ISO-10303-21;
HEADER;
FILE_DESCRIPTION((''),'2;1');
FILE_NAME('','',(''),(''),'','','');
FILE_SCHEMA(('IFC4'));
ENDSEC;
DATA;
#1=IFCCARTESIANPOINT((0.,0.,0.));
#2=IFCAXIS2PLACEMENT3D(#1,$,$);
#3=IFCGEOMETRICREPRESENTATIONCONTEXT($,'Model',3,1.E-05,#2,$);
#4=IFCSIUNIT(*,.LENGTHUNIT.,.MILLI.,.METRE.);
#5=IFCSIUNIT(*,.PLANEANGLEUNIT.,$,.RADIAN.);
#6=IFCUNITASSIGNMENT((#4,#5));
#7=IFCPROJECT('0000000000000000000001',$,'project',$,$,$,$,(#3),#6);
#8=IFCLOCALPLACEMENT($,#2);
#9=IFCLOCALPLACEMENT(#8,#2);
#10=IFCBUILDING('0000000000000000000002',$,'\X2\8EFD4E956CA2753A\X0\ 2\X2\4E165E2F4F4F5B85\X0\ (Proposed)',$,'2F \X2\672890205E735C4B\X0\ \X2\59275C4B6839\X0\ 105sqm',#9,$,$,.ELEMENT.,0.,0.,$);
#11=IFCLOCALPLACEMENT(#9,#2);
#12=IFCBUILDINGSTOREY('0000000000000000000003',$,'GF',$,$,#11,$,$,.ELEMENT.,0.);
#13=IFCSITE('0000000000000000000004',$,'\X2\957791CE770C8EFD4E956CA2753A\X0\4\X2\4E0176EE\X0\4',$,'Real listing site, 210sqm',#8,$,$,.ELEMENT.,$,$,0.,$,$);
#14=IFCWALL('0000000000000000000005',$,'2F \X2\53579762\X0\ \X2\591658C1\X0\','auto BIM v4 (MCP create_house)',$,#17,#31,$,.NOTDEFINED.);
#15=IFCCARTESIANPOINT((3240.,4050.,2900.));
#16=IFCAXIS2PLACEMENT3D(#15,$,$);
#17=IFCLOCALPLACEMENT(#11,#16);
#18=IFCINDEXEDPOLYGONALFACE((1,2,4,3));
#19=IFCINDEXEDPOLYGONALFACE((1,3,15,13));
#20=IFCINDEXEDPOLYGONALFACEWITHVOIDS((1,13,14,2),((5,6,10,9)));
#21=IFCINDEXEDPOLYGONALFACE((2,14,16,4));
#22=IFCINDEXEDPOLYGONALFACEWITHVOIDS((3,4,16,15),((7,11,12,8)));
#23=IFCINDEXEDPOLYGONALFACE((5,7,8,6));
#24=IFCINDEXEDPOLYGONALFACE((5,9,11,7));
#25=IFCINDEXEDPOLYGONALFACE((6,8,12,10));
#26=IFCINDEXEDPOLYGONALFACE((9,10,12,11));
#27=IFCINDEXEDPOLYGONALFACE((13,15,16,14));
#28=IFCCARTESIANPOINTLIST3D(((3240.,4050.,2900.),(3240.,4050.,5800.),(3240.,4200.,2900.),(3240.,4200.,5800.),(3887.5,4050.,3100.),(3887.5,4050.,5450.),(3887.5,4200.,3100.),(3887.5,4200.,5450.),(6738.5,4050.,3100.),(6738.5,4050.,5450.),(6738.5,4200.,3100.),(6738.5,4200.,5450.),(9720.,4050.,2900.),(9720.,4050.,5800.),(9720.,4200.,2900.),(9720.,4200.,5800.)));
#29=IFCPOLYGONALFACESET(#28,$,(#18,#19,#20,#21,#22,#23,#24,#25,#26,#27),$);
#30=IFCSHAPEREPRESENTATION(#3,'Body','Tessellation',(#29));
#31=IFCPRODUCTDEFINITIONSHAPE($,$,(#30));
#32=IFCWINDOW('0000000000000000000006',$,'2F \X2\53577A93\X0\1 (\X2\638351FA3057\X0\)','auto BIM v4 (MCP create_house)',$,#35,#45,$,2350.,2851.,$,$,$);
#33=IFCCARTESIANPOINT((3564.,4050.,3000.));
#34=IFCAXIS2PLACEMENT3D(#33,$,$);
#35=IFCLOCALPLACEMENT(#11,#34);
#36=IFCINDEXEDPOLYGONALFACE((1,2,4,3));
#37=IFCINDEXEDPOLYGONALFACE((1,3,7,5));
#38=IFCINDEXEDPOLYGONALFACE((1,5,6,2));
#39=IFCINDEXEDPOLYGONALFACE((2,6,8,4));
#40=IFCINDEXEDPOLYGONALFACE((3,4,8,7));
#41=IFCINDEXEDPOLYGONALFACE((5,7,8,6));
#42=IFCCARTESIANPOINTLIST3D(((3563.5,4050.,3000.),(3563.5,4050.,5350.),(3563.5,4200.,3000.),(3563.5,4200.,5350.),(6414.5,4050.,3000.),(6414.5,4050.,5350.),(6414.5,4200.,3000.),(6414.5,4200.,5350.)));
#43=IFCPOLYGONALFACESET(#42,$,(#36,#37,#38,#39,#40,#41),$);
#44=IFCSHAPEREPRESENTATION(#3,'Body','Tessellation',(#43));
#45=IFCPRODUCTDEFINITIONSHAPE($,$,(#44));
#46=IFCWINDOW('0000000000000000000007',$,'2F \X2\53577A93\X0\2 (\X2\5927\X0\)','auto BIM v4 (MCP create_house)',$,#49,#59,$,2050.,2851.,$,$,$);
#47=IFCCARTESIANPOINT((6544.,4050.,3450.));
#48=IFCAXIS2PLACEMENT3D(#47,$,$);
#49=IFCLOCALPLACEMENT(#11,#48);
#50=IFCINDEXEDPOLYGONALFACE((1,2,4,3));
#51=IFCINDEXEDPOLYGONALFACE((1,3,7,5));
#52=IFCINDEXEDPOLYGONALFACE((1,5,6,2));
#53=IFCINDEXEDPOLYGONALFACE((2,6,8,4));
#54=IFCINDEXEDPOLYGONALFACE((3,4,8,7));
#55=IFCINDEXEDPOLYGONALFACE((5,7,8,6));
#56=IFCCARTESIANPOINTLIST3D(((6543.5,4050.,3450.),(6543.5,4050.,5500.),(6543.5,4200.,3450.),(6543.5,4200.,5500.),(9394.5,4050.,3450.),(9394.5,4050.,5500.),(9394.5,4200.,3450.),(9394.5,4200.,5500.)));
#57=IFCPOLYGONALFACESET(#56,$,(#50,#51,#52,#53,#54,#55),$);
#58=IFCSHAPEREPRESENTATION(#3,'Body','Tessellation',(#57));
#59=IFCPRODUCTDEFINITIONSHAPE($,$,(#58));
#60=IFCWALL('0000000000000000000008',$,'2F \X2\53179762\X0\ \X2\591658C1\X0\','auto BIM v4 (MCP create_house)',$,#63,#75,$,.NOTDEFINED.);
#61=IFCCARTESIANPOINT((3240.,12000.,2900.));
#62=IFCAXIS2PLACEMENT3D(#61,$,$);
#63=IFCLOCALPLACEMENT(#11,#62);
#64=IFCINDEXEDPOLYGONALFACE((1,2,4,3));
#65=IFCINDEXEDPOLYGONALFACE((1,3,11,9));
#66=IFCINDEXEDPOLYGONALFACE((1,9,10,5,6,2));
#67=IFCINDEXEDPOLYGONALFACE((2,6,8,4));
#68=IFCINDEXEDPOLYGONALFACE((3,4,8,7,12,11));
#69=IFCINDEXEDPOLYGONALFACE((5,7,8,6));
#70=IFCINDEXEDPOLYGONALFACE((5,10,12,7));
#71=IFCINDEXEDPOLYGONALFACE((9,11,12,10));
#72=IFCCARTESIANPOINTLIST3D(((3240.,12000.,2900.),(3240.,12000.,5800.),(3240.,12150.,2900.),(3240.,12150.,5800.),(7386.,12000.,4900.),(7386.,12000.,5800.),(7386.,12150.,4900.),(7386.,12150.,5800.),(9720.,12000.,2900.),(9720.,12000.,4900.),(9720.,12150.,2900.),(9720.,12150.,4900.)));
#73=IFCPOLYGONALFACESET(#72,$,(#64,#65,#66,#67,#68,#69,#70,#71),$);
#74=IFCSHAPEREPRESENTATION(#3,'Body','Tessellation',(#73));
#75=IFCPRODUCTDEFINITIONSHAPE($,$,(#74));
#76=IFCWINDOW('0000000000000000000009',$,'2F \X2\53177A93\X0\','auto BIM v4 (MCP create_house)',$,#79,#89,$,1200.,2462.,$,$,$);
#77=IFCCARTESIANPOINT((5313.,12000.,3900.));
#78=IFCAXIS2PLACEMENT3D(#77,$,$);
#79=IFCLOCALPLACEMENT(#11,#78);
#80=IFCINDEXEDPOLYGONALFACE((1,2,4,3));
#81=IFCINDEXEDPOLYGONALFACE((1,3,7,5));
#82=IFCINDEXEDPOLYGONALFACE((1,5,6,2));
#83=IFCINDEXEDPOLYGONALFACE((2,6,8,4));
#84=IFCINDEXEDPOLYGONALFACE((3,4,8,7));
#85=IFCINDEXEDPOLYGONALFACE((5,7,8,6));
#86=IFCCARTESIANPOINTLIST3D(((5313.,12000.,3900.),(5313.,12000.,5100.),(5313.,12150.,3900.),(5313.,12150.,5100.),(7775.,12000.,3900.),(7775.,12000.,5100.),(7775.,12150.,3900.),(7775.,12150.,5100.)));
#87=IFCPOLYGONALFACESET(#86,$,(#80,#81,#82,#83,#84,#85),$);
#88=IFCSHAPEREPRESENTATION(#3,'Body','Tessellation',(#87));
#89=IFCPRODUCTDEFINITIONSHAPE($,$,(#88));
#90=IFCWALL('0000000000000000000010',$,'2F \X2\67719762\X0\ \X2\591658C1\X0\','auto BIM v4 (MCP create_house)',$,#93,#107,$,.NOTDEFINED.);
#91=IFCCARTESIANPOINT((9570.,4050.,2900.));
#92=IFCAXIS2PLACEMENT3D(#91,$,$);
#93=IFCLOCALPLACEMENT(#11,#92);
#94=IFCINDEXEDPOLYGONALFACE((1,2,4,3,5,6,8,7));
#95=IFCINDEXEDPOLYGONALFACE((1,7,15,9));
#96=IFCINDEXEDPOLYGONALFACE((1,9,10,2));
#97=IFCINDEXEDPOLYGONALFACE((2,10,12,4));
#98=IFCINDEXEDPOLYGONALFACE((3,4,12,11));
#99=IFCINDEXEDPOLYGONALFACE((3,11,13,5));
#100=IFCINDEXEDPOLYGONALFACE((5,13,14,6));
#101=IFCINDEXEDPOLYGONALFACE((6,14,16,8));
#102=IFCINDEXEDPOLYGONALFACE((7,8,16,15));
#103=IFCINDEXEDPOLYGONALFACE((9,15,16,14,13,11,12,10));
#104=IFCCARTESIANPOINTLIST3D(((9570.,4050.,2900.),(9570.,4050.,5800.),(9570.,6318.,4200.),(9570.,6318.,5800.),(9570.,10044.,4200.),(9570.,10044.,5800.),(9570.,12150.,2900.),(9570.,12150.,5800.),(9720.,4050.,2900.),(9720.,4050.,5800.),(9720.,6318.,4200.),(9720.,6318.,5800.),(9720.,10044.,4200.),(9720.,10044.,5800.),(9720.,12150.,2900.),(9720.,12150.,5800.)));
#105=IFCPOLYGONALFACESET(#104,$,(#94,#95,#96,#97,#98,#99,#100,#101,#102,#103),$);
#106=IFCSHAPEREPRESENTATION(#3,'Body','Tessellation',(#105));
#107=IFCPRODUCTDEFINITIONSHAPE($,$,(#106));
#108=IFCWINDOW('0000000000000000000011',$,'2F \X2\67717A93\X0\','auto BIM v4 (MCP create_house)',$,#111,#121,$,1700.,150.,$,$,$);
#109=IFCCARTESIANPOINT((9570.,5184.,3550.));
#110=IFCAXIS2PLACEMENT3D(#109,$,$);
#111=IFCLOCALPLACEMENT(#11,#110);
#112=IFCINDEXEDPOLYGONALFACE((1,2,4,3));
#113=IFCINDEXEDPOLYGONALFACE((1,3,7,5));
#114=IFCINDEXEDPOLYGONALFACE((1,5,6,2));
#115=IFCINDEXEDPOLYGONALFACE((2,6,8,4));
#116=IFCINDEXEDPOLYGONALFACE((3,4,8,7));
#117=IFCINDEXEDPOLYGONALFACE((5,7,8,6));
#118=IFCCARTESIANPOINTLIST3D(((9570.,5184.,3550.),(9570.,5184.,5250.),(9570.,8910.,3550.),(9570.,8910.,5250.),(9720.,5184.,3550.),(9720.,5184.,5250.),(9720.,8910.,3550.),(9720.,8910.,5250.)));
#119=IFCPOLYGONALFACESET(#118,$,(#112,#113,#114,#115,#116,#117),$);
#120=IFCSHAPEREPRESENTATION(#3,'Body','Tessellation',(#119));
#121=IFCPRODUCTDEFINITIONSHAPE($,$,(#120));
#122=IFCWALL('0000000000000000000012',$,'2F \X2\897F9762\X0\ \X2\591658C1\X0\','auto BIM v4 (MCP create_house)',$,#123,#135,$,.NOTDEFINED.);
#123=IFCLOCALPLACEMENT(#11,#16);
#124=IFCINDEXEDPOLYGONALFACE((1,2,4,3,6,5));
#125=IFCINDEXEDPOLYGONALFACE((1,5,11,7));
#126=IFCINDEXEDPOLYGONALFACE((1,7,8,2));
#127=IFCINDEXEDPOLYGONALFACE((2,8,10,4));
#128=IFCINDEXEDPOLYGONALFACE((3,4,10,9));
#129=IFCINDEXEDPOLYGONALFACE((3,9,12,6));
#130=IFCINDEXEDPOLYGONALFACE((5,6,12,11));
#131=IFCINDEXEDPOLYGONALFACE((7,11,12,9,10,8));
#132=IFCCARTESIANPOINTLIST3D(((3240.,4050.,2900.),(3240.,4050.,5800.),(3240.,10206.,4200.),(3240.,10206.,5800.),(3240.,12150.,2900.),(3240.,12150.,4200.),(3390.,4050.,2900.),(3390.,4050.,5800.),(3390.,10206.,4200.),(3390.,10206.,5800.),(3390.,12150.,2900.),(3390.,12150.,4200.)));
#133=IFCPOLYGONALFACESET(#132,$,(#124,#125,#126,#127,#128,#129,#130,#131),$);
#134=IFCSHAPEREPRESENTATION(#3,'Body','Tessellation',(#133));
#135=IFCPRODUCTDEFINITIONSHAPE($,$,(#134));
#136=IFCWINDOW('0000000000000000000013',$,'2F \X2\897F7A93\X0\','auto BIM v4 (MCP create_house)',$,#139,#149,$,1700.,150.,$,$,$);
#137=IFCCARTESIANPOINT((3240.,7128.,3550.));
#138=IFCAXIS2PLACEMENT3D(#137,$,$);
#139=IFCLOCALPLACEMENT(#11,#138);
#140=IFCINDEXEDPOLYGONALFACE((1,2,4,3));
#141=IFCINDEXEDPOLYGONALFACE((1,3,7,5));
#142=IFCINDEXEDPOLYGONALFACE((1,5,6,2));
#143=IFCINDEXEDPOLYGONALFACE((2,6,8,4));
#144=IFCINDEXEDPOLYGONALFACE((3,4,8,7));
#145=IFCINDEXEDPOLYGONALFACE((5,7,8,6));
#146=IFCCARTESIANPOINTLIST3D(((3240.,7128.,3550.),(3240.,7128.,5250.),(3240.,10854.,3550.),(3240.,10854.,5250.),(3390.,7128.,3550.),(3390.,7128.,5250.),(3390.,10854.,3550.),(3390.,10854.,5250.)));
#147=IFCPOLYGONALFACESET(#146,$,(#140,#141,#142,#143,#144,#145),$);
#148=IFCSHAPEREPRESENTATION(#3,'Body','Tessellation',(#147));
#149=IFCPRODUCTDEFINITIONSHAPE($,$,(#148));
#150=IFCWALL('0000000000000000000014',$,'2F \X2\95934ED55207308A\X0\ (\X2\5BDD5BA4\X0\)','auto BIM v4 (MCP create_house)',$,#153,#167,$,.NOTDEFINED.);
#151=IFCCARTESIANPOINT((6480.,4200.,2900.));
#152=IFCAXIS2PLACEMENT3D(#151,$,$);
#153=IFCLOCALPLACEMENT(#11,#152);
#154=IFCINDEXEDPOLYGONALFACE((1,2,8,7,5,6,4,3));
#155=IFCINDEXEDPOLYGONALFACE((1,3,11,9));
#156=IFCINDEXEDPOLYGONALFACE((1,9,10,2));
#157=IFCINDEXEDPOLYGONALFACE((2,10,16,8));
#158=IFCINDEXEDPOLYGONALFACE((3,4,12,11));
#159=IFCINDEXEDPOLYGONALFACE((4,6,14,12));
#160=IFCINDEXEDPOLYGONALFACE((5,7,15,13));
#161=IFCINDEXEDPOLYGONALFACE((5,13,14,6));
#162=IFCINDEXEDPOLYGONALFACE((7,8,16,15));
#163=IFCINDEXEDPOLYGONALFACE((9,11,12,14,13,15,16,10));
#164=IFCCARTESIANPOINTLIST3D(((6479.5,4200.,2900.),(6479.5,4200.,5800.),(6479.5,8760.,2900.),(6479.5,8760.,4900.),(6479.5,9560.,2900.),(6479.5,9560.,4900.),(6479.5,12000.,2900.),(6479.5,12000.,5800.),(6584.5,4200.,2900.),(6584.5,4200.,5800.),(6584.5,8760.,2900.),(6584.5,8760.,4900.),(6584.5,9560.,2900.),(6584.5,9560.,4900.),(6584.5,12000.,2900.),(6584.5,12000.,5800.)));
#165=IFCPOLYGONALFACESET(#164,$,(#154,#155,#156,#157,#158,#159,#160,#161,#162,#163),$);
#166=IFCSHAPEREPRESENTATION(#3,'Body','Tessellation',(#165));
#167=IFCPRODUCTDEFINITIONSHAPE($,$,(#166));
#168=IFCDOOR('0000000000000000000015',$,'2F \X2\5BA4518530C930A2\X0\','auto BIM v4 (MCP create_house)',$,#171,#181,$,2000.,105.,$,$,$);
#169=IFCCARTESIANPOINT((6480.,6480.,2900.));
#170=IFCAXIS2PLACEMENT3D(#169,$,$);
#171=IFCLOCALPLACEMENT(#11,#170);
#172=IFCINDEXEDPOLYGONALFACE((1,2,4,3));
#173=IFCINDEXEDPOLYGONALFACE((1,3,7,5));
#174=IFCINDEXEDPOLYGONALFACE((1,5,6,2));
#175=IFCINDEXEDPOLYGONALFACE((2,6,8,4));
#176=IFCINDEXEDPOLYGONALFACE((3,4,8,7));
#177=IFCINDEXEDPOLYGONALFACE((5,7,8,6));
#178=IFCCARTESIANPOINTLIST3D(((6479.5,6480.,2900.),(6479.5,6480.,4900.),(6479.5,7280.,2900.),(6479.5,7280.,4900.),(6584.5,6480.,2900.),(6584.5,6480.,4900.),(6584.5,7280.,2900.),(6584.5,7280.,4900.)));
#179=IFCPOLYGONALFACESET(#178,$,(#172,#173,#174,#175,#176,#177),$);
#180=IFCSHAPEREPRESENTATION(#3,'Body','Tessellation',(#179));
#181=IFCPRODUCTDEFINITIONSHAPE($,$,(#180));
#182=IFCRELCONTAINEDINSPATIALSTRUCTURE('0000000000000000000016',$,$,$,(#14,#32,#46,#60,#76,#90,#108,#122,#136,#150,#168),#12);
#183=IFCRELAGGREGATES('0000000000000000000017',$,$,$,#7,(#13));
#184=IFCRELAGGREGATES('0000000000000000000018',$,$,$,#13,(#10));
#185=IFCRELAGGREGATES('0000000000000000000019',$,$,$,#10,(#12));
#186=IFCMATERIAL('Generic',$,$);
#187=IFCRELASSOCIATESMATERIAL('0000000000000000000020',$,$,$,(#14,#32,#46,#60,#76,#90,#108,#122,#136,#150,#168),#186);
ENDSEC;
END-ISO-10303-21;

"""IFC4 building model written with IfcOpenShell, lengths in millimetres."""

from ifc_helpers import new_model, si_unit, frame, frame_2d, origin, place, context, project, spatial, rectangle, extrude, material, element, fill, save


model = new_model("IFC4")

# Units and contexts
model_context = context("Model", 3, precision=1e-05, world=origin())
ifc_project = project(units=[si_unit("LENGTHUNIT", "METRE", prefix="MILLI"), si_unit("PLANEANGLEUNIT", "RADIAN")], contexts=[model_context])

# Site, building, storey
site_placement = place(None, origin())
site = spatial("IfcSite", under=ifc_project, at=site_placement, Name="長野県軽井沢町4丁目4", ObjectType="Real listing site, 210sqm", CompositionType="ELEMENT", RefElevation=0.0)
building_placement = place(site_placement, origin())
building = spatial("IfcBuilding", under=site, at=building_placement, Name="軽井沢町 2世帯住宅 (Proposed)", ObjectType="2F 木造平屋 大屋根 105sqm", CompositionType="ELEMENT", ElevationOfRefHeight=0.0, ElevationOfTerrain=0.0)
storey_placement = place(building_placement, origin())
storey = spatial("IfcBuildingStorey", under=building, at=storey_placement, Name="GF", CompositionType="ELEMENT", Elevation=0.0)

# Shared definitions
ifc_material = material(Name="Generic")

# Wall, openings, windows
wall_1_placement = place(storey_placement, frame((3240.0, 4050.0, 2900.0)))
wall_1 = element("IfcWall", 1, at=wall_1_placement, inside=storey, material=ifc_material, Name="2F 南面 外壁", Description="auto BIM v4 (MCP create_house)", PredefinedType="NOTDEFINED", context=model_context, shape_type="SweptSolid", body=[
    extrude(rectangle(XDim=6480.0, YDim=150.0, at=frame_2d((3240.0, 75.0))), frame((3240.0, 4050.0, 2900.0)), (0.0, 0.0, 1.0), 2900.0),
])
opening_1_placement = place(storey_placement, frame((3564.0, 4050.0, 3000.0)))
opening_1 = element("IfcOpeningElement", 2, at=opening_1_placement, cuts=wall_1, PredefinedType="NOTDEFINED", context=model_context, shape_type="SweptSolid", body=[
    extrude(rectangle(XDim=2851.0, YDim=150.0, at=frame_2d((1425.0, 75.0))), frame((3564.0, 4050.0, 3000.0)), (0.0, 0.0, 1.0), 2350.0),
])
opening_2_placement = place(storey_placement, frame((6544.0, 4050.0, 3450.0)))
opening_2 = element("IfcOpeningElement", 3, at=opening_2_placement, cuts=wall_1, PredefinedType="NOTDEFINED", context=model_context, shape_type="SweptSolid", body=[
    extrude(rectangle(XDim=2851.0, YDim=150.0, at=frame_2d((1425.0, 75.0))), frame((6544.0, 4050.0, 3450.0)), (0.0, 0.0, 1.0), 2050.0),
])
window_1_placement = place(storey_placement, frame((3564.0, 4050.0, 3000.0)))
window_1 = element("IfcWindow", 4, at=window_1_placement, inside=storey, material=ifc_material, Name="2F 南窓1 (掃出し)", Description="auto BIM v4 (MCP create_house)", OverallHeight=2350.0, OverallWidth=2851.0, context=model_context, shape_type="SweptSolid", body=[
    extrude(rectangle(XDim=2851.0, YDim=150.0, at=frame_2d((1425.0, 75.0))), frame((3564.0, 4050.0, 3000.0)), (0.0, 0.0, 1.0), 2350.0),
])
fill(opening_1, window_1)
window_2_placement = place(storey_placement, frame((6544.0, 4050.0, 3450.0)))
window_2 = element("IfcWindow", 5, at=window_2_placement, inside=storey, material=ifc_material, Name="2F 南窓2 (大)", Description="auto BIM v4 (MCP create_house)", OverallHeight=2050.0, OverallWidth=2851.0, context=model_context, shape_type="SweptSolid", body=[
    extrude(rectangle(XDim=2851.0, YDim=150.0, at=frame_2d((1425.0, 75.0))), frame((6544.0, 4050.0, 3450.0)), (0.0, 0.0, 1.0), 2050.0),
])
fill(opening_2, window_2)

# Walls, openings, windows
wall_2_placement = place(storey_placement, frame((3240.0, 12000.0, 2900.0)))
wall_2 = element("IfcWall", 6, at=wall_2_placement, inside=storey, material=ifc_material, Name="2F 北面 外壁", Description="auto BIM v4 (MCP create_house)", PredefinedType="NOTDEFINED", context=model_context, shape_type="SweptSolid", body=[
    extrude(rectangle(XDim=6480.0, YDim=150.0, at=frame_2d((3240.0, 75.0))), frame((3240.0, 12000.0, 2900.0)), (0.0, 0.0, 1.0), 2900.0),
])
opening_3_placement = place(storey_placement, frame((5313.0, 12000.0, 3900.0)))
opening_3 = element("IfcOpeningElement", 7, at=opening_3_placement, cuts=wall_2, PredefinedType="NOTDEFINED", context=model_context, shape_type="SweptSolid", body=[
    extrude(rectangle(XDim=2462.0, YDim=150.0, at=frame_2d((1231.0, 75.0))), frame((5313.0, 12000.0, 3900.0)), (0.0, 0.0, 1.0), 1200.0),
])
window_3_placement = place(storey_placement, frame((5313.0, 12000.0, 3900.0)))
window_3 = element("IfcWindow", 8, at=window_3_placement, inside=storey, material=ifc_material, Name="2F 北窓", Description="auto BIM v4 (MCP create_house)", OverallHeight=1200.0, OverallWidth=2462.0, context=model_context, shape_type="SweptSolid", body=[
    extrude(rectangle(XDim=2462.0, YDim=150.0, at=frame_2d((1231.0, 75.0))), frame((5313.0, 12000.0, 3900.0)), (0.0, 0.0, 1.0), 1200.0),
])
fill(opening_3, window_3)
wall_3_placement = place(storey_placement, frame((9570.0, 4050.0, 2900.0)))
wall_3 = element("IfcWall", 9, at=wall_3_placement, inside=storey, material=ifc_material, Name="2F 東面 外壁", Description="auto BIM v4 (MCP create_house)", PredefinedType="NOTDEFINED", context=model_context, shape_type="SweptSolid", body=[
    extrude(rectangle(XDim=150.0, YDim=8100.0, at=frame_2d((75.0, 4050.0))), frame((9570.0, 4050.0, 2900.0)), (0.0, 0.0, 1.0), 2900.0),
])
opening_4_placement = place(storey_placement, frame((9570.0, 5184.0, 3550.0)))
opening_4 = element("IfcOpeningElement", 10, at=opening_4_placement, cuts=wall_3, PredefinedType="NOTDEFINED", context=model_context, shape_type="SweptSolid", body=[
    extrude(rectangle(XDim=150.0, YDim=3726.0, at=frame_2d((75.0, 1863.0))), frame((9570.0, 5184.0, 3550.0)), (0.0, 0.0, 1.0), 1700.0),
])
window_4_placement = place(storey_placement, frame((9570.0, 5184.0, 3550.0)))
window_4 = element("IfcWindow", 11, at=window_4_placement, inside=storey, material=ifc_material, Name="2F 東窓", Description="auto BIM v4 (MCP create_house)", OverallHeight=1700.0, OverallWidth=150.0, context=model_context, shape_type="SweptSolid", body=[
    extrude(rectangle(XDim=150.0, YDim=3726.0, at=frame_2d((75.0, 1863.0))), frame((9570.0, 5184.0, 3550.0)), (0.0, 0.0, 1.0), 1700.0),
])
fill(opening_4, window_4)
wall_4_placement = place(storey_placement, frame((3240.0, 4050.0, 2900.0)))
wall_4 = element("IfcWall", 12, at=wall_4_placement, inside=storey, material=ifc_material, Name="2F 西面 外壁", Description="auto BIM v4 (MCP create_house)", PredefinedType="NOTDEFINED", context=model_context, shape_type="SweptSolid", body=[
    extrude(rectangle(XDim=150.0, YDim=8100.0, at=frame_2d((75.0, 4050.0))), frame((3240.0, 4050.0, 2900.0)), (0.0, 0.0, 1.0), 2900.0),
])
opening_5_placement = place(storey_placement, frame((3240.0, 7128.0, 3550.0)))
opening_5 = element("IfcOpeningElement", 13, at=opening_5_placement, cuts=wall_4, PredefinedType="NOTDEFINED", context=model_context, shape_type="SweptSolid", body=[
    extrude(rectangle(XDim=150.0, YDim=3726.0, at=frame_2d((75.0, 1863.0))), frame((3240.0, 7128.0, 3550.0)), (0.0, 0.0, 1.0), 1700.0),
])
window_5_placement = place(storey_placement, frame((3240.0, 7128.0, 3550.0)))
window_5 = element("IfcWindow", 14, at=window_5_placement, inside=storey, material=ifc_material, Name="2F 西窓", Description="auto BIM v4 (MCP create_house)", OverallHeight=1700.0, OverallWidth=150.0, context=model_context, shape_type="SweptSolid", body=[
    extrude(rectangle(XDim=150.0, YDim=3726.0, at=frame_2d((75.0, 1863.0))), frame((3240.0, 7128.0, 3550.0)), (0.0, 0.0, 1.0), 1700.0),
])
fill(opening_5, window_5)

# Wall, opening, door
wall_5_placement = place(storey_placement, frame((6480.0, 4200.0, 2900.0)))
wall_5 = element("IfcWall", 15, at=wall_5_placement, inside=storey, material=ifc_material, Name="2F 間仕切り (寝室)", Description="auto BIM v4 (MCP create_house)", PredefinedType="NOTDEFINED", context=model_context, shape_type="SweptSolid", body=[
    extrude(rectangle(XDim=105.0, YDim=7800.0, at=frame_2d((52.0, 3900.0))), frame((6480.0, 4200.0, 2900.0)), (0.0, 0.0, 1.0), 2900.0),
])
opening_6_placement = place(storey_placement, frame((6480.0, 6480.0, 2900.0)))
opening_6 = element("IfcOpeningElement", 16, at=opening_6_placement, cuts=wall_5, PredefinedType="NOTDEFINED", context=model_context, shape_type="SweptSolid", body=[
    extrude(rectangle(XDim=105.0, YDim=800.0, at=frame_2d((52.0, 400.0))), frame((6480.0, 6480.0, 2900.0)), (0.0, 0.0, 1.0), 2000.0),
])
door_1_placement = place(storey_placement, frame((6480.0, 6480.0, 2900.0)))
door_1 = element("IfcDoor", 17, at=door_1_placement, inside=storey, material=ifc_material, Name="2F 室内ドア", Description="auto BIM v4 (MCP create_house)", OverallHeight=2000.0, OverallWidth=105.0, context=model_context, shape_type="SweptSolid", body=[
    extrude(rectangle(XDim=105.0, YDim=800.0, at=frame_2d((52.0, 400.0))), frame((6480.0, 6480.0, 2900.0)), (0.0, 0.0, 1.0), 2000.0),
])
fill(opening_6, door_1)

save(model, "model.ifc")
